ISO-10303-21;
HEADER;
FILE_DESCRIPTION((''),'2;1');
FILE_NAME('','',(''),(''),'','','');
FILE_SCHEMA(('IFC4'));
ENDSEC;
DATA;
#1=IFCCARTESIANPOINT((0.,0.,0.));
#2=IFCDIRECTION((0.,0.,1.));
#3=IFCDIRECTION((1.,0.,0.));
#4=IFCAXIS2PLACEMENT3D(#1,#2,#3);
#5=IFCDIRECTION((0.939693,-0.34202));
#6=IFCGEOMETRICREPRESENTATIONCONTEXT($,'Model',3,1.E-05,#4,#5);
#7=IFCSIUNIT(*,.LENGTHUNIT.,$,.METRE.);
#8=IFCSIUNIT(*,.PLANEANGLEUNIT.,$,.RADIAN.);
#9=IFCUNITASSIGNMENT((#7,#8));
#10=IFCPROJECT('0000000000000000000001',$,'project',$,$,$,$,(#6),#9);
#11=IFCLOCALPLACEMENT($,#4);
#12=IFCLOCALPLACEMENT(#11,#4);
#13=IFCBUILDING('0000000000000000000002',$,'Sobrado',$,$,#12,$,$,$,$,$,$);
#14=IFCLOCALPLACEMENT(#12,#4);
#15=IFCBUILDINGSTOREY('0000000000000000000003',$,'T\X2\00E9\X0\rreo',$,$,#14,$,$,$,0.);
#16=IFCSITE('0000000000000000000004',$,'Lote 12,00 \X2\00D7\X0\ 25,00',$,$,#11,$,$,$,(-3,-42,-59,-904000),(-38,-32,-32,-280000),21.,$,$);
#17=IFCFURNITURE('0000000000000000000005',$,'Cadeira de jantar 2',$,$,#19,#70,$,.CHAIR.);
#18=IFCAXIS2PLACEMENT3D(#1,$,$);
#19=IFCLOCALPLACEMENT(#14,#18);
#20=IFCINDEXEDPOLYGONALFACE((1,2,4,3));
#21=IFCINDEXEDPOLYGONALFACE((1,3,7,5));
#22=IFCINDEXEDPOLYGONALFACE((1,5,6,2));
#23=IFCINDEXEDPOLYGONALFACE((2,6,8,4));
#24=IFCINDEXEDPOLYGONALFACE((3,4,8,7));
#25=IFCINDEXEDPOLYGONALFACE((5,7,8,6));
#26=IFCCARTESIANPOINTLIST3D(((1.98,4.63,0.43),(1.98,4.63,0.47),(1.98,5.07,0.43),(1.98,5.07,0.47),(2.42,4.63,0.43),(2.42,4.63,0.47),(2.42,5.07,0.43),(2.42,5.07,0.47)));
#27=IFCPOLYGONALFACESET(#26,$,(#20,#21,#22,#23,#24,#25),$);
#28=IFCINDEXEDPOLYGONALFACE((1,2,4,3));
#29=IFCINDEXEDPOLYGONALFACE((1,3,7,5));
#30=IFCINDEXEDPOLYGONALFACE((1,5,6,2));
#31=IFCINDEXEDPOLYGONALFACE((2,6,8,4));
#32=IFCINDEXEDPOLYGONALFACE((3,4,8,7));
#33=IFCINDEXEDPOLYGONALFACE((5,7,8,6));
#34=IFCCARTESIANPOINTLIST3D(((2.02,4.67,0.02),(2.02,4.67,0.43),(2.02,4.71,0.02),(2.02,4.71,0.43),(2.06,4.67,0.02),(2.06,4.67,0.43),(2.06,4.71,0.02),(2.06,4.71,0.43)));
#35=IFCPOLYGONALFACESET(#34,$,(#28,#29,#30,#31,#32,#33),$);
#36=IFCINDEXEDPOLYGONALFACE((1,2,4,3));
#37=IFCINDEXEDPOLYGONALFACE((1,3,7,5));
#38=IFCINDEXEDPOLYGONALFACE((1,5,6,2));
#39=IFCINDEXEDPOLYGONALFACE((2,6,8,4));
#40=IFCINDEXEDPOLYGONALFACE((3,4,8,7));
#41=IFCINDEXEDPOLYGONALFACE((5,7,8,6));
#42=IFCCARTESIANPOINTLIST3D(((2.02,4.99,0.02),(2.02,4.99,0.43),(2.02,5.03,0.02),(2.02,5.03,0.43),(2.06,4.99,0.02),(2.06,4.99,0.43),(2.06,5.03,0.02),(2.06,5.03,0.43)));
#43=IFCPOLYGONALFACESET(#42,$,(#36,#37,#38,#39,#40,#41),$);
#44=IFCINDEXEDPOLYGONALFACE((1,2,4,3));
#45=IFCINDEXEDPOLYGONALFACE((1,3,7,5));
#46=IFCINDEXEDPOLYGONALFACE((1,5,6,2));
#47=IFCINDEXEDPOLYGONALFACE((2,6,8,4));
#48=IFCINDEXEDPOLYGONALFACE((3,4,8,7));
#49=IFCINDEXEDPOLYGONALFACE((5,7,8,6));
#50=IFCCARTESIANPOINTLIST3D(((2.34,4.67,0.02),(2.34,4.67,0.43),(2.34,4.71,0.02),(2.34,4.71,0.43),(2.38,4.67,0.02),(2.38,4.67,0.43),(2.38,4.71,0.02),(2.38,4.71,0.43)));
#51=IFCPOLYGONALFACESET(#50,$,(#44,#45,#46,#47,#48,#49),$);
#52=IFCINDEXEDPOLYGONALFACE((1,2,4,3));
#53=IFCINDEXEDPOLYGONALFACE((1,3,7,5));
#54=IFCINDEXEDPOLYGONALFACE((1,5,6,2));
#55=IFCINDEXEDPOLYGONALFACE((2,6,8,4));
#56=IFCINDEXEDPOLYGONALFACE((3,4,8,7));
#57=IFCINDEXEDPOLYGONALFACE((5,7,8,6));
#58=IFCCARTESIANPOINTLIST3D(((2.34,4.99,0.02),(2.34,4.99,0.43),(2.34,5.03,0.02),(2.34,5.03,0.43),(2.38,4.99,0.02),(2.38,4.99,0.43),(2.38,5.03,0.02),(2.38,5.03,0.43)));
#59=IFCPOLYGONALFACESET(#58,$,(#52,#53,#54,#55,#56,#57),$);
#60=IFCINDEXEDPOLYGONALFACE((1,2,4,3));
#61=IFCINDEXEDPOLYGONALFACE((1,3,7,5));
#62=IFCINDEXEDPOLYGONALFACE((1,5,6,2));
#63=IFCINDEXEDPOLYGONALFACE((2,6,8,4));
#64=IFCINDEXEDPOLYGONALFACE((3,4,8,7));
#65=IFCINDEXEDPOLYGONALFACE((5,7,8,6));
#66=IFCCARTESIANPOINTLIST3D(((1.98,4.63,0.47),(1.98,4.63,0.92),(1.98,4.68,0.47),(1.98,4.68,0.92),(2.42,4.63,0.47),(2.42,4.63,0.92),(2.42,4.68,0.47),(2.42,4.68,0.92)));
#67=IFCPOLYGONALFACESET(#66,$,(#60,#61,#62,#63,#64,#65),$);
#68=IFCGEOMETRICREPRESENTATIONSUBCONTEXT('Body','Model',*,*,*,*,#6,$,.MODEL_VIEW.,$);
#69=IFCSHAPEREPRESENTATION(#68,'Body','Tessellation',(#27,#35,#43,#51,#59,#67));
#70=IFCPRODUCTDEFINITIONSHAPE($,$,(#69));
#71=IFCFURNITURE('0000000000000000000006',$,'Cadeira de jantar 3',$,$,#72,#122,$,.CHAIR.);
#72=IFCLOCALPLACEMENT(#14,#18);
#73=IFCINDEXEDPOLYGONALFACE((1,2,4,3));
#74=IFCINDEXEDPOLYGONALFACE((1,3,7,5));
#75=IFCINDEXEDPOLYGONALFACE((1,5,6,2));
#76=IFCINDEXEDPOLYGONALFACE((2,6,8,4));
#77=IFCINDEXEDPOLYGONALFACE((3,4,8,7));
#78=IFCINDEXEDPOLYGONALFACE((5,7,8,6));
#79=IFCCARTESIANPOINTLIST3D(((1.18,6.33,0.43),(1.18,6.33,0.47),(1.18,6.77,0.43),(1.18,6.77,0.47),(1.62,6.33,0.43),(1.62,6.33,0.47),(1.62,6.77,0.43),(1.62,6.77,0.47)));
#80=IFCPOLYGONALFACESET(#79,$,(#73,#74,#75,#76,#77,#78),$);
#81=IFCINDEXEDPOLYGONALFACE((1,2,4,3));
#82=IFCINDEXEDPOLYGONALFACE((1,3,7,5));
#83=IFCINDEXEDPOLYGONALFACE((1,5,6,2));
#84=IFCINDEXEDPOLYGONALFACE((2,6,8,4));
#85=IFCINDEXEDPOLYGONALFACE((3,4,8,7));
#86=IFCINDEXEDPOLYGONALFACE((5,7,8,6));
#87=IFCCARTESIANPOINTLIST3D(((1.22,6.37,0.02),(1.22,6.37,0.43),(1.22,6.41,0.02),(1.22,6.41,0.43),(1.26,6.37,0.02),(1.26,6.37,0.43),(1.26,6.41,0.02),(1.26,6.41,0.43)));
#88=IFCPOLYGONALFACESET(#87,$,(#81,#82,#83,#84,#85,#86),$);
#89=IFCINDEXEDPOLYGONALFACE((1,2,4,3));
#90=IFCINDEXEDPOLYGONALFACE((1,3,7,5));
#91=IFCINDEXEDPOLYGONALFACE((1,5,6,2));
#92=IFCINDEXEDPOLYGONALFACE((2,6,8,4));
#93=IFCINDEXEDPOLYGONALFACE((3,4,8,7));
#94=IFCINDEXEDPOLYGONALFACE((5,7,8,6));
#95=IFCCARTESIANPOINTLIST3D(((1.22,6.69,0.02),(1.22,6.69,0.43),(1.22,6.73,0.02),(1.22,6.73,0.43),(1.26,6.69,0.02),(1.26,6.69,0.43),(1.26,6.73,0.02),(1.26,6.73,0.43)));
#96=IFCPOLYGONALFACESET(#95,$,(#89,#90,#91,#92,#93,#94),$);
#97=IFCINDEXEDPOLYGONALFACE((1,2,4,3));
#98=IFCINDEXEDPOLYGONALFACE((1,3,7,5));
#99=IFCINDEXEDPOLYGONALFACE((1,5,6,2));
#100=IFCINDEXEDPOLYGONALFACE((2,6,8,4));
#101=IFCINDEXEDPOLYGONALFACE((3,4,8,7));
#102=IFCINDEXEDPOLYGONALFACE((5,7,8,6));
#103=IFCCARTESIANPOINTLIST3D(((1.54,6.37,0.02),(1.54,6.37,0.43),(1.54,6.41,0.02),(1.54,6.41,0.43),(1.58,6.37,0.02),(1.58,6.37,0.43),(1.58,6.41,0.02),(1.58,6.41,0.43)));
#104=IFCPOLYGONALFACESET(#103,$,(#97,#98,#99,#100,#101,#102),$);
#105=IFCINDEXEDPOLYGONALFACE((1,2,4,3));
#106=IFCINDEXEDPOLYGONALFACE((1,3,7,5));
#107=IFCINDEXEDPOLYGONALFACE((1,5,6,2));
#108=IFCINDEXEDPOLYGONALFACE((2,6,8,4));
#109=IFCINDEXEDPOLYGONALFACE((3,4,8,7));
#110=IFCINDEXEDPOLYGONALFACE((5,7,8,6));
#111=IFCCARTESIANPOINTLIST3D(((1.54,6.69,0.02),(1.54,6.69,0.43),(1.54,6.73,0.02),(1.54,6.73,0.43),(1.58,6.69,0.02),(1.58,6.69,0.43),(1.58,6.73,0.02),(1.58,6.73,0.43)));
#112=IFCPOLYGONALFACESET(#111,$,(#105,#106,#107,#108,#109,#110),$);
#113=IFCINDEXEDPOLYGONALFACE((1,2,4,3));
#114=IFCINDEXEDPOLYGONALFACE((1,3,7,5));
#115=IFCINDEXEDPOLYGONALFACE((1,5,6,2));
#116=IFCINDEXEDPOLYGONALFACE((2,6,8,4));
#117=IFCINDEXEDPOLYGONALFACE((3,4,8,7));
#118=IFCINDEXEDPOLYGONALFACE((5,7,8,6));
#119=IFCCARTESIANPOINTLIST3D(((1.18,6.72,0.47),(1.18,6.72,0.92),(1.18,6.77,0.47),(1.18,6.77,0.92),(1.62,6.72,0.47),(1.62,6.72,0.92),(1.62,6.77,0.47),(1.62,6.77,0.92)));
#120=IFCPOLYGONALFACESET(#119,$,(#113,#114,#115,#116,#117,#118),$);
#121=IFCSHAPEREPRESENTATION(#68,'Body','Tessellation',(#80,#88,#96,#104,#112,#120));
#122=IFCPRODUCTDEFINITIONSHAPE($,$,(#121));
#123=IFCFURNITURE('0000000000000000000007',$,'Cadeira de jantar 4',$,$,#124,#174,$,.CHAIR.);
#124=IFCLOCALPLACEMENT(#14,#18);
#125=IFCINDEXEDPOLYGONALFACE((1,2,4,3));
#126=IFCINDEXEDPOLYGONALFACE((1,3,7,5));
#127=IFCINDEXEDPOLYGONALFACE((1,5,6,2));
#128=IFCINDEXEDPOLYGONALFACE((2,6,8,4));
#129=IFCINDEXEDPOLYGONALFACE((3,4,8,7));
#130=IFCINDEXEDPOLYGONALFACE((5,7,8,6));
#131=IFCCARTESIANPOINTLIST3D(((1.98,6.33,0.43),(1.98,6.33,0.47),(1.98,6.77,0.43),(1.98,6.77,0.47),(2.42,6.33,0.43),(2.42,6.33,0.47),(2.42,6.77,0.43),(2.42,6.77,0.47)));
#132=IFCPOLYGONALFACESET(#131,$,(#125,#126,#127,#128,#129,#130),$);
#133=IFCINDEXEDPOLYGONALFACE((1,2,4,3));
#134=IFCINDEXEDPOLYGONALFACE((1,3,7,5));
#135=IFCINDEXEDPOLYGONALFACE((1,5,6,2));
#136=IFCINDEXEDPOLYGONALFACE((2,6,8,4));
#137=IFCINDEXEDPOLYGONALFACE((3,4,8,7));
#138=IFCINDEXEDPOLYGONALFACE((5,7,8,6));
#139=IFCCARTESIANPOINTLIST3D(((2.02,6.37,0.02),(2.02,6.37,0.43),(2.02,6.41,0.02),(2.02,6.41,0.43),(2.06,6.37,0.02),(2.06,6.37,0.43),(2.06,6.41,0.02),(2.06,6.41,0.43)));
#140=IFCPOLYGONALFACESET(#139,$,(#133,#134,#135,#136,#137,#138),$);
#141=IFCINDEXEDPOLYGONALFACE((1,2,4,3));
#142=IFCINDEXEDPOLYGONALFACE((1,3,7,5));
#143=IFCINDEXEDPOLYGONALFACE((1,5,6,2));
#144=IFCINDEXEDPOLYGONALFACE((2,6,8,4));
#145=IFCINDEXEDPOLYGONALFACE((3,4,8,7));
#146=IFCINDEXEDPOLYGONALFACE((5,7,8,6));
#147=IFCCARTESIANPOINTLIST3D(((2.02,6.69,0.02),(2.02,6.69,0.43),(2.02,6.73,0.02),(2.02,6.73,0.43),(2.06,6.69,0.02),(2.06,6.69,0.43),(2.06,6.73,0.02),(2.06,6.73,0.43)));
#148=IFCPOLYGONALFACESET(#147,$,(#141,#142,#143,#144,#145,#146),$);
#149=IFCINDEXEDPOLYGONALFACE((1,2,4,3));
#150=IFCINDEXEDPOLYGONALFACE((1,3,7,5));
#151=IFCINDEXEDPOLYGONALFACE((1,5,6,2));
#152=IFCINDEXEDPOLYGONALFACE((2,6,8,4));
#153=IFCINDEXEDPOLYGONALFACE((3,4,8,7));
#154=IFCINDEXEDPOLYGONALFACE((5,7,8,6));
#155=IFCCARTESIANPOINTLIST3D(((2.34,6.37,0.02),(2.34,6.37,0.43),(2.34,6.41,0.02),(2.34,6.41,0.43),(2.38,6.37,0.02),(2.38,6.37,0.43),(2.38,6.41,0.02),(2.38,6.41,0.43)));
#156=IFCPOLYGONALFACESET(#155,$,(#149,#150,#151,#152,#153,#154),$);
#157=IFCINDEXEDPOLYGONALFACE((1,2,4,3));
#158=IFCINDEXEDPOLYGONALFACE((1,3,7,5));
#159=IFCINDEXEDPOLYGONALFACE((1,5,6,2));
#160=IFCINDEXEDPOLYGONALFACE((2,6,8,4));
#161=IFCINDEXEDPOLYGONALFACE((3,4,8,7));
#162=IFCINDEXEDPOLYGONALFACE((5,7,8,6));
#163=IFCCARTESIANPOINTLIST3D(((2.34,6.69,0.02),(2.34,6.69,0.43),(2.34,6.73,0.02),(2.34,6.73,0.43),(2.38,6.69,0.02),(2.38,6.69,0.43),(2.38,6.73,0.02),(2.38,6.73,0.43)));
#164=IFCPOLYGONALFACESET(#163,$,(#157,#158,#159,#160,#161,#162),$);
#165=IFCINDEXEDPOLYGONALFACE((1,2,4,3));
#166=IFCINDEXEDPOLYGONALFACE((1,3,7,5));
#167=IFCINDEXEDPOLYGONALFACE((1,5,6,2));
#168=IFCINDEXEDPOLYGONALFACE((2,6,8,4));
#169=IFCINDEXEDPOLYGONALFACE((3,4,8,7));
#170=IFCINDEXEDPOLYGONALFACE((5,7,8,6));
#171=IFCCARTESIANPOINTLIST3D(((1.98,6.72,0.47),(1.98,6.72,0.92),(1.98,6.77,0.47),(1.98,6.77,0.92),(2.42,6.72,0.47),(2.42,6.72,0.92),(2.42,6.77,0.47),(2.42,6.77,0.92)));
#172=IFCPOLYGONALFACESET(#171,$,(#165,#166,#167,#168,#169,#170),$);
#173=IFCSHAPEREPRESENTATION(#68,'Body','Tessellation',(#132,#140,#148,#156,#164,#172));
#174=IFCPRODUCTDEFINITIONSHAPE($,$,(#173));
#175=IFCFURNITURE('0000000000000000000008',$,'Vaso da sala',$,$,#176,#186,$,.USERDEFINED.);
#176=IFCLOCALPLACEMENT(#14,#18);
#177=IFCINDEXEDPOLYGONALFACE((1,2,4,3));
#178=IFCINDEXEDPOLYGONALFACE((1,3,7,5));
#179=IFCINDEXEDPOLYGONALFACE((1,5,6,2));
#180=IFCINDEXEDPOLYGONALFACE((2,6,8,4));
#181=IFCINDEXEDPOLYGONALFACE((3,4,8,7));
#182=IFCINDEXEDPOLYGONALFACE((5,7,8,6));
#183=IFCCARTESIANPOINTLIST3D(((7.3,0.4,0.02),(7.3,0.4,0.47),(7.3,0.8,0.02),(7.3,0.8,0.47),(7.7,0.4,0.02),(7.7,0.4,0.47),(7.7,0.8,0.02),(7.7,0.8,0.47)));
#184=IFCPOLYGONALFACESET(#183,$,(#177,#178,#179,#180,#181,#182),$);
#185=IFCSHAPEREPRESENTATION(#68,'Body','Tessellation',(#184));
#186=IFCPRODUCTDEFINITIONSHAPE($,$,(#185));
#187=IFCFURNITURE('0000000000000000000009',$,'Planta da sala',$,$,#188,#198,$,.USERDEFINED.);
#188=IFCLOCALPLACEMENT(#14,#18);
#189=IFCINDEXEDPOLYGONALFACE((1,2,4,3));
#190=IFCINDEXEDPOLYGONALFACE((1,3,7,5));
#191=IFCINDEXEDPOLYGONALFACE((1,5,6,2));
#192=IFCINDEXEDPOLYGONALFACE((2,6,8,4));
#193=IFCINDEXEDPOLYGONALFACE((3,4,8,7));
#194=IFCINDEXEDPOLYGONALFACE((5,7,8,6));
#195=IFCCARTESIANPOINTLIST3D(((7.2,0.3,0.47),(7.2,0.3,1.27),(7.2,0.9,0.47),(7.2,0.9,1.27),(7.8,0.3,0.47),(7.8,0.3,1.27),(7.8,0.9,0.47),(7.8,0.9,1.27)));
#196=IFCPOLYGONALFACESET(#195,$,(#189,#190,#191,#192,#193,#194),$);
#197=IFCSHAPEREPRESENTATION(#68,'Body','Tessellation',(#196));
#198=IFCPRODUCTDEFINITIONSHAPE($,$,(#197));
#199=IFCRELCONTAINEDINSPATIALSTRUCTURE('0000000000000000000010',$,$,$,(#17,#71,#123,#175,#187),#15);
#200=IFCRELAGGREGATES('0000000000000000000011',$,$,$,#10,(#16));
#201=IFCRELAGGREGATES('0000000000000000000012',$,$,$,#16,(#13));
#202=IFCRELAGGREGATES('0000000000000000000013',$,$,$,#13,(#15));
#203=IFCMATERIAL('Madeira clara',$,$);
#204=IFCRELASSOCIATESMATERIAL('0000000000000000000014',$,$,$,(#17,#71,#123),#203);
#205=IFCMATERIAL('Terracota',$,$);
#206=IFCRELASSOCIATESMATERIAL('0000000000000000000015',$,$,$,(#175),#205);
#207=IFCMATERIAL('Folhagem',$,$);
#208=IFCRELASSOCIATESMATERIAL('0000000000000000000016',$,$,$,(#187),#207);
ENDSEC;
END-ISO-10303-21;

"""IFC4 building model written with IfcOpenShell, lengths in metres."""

from ifc_helpers import new_model, si_unit, direction, frame, origin_with_axes, place, context, subcontext, project, spatial, line, indexed_curve, outline, extrude, material, element, save


model = new_model("IFC4")

# Units and contexts
model_context = context("Model", 3, precision=1e-05, world=origin_with_axes(), true_north=direction((0.939693, -0.34202)))
body_context = subcontext(model_context, "Body", "Model", "MODEL_VIEW")
ifc_project = project(units=[si_unit("LENGTHUNIT", "METRE"), si_unit("PLANEANGLEUNIT", "RADIAN")], contexts=[model_context])

# Site, building, storey
site_placement = place(None, origin_with_axes())
site = spatial("IfcSite", under=ifc_project, at=site_placement, Name="Lote 12,00 × 25,00", RefLatitude=(-3, -42, -59, -904000), RefLongitude=(-38, -32, -32, -280000), RefElevation=21.0)
building_placement = place(site_placement, origin_with_axes())
building = spatial("IfcBuilding", under=site, at=building_placement, Name="Sobrado")
storey_placement = place(building_placement, origin_with_axes())
storey = spatial("IfcBuildingStorey", under=building, at=storey_placement, Name="Térreo", Elevation=0.0)

# Furniture
ifc_material_1 = material(Name="Madeira clara")
furniture_1_placement = place(storey_placement, origin_with_axes())
element("IfcFurniture", 1, at=furniture_1_placement, inside=storey, material=ifc_material_1, Name="Cadeira de jantar 2", PredefinedType="CHAIR", context=body_context, shape_type="SweptSolid", body=[
    extrude(outline(indexed_curve([(1.98, 4.63), (2.42, 4.63), (2.42, 5.07), (1.98, 5.07)], segments=[line(1, 2, 3, 4, 1)])), frame((0.0, 0.0, 0.43), z_axis=(0.0, 0.0, 1.0), x_axis=(1.0, 0.0, 0.0)), (0.0, 0.0, 1.0), 0.04),
    extrude(outline(indexed_curve([(2.02, 4.67), (2.06, 4.67), (2.06, 4.71), (2.02, 4.71)], segments=[line(1, 2, 3, 4, 1)])), frame((0.0, 0.0, 0.02), z_axis=(0.0, 0.0, 1.0), x_axis=(1.0, 0.0, 0.0)), (0.0, 0.0, 1.0), 0.41),
    extrude(outline(indexed_curve([(2.02, 4.99), (2.06, 4.99), (2.06, 5.03), (2.02, 5.03)], segments=[line(1, 2, 3, 4, 1)])), frame((0.0, 0.0, 0.02), z_axis=(0.0, 0.0, 1.0), x_axis=(1.0, 0.0, 0.0)), (0.0, 0.0, 1.0), 0.41),
    extrude(outline(indexed_curve([(2.34, 4.67), (2.38, 4.67), (2.38, 4.71), (2.34, 4.71)], segments=[line(1, 2, 3, 4, 1)])), frame((0.0, 0.0, 0.02), z_axis=(0.0, 0.0, 1.0), x_axis=(1.0, 0.0, 0.0)), (0.0, 0.0, 1.0), 0.41),
    extrude(outline(indexed_curve([(2.34, 4.99), (2.38, 4.99), (2.38, 5.03), (2.34, 5.03)], segments=[line(1, 2, 3, 4, 1)])), frame((0.0, 0.0, 0.02), z_axis=(0.0, 0.0, 1.0), x_axis=(1.0, 0.0, 0.0)), (0.0, 0.0, 1.0), 0.41),
    extrude(outline(indexed_curve([(1.98, 4.63), (2.42, 4.63), (2.42, 4.68), (1.98, 4.68)], segments=[line(1, 2, 3, 4, 1)])), frame((0.0, 0.0, 0.47), z_axis=(0.0, 0.0, 1.0), x_axis=(1.0, 0.0, 0.0)), (0.0, 0.0, 1.0), 0.45),
])
furniture_2_placement = place(storey_placement, origin_with_axes())
element("IfcFurniture", 2, at=furniture_2_placement, inside=storey, material=ifc_material_1, Name="Cadeira de jantar 3", PredefinedType="CHAIR", context=body_context, shape_type="SweptSolid", body=[
    extrude(outline(indexed_curve([(1.18, 6.33), (1.62, 6.33), (1.62, 6.77), (1.18, 6.77)], segments=[line(1, 2, 3, 4, 1)])), frame((0.0, 0.0, 0.43), z_axis=(0.0, 0.0, 1.0), x_axis=(1.0, 0.0, 0.0)), (0.0, 0.0, 1.0), 0.04),
    extrude(outline(indexed_curve([(1.22, 6.37), (1.26, 6.37), (1.26, 6.41), (1.22, 6.41)], segments=[line(1, 2, 3, 4, 1)])), frame((0.0, 0.0, 0.02), z_axis=(0.0, 0.0, 1.0), x_axis=(1.0, 0.0, 0.0)), (0.0, 0.0, 1.0), 0.41),
    extrude(outline(indexed_curve([(1.22, 6.69), (1.26, 6.69), (1.26, 6.73), (1.22, 6.73)], segments=[line(1, 2, 3, 4, 1)])), frame((0.0, 0.0, 0.02), z_axis=(0.0, 0.0, 1.0), x_axis=(1.0, 0.0, 0.0)), (0.0, 0.0, 1.0), 0.41),
    extrude(outline(indexed_curve([(1.54, 6.37), (1.58, 6.37), (1.58, 6.41), (1.54, 6.41)], segments=[line(1, 2, 3, 4, 1)])), frame((0.0, 0.0, 0.02), z_axis=(0.0, 0.0, 1.0), x_axis=(1.0, 0.0, 0.0)), (0.0, 0.0, 1.0), 0.41),
    extrude(outline(indexed_curve([(1.54, 6.69), (1.58, 6.69), (1.58, 6.73), (1.54, 6.73)], segments=[line(1, 2, 3, 4, 1)])), frame((0.0, 0.0, 0.02), z_axis=(0.0, 0.0, 1.0), x_axis=(1.0, 0.0, 0.0)), (0.0, 0.0, 1.0), 0.41),
    extrude(outline(indexed_curve([(1.18, 6.72), (1.62, 6.72), (1.62, 6.77), (1.18, 6.77)], segments=[line(1, 2, 3, 4, 1)])), frame((0.0, 0.0, 0.47), z_axis=(0.0, 0.0, 1.0), x_axis=(1.0, 0.0, 0.0)), (0.0, 0.0, 1.0), 0.45),
])
furniture_3_placement = place(storey_placement, origin_with_axes())
element("IfcFurniture", 3, at=furniture_3_placement, inside=storey, material=ifc_material_1, Name="Cadeira de jantar 4", PredefinedType="CHAIR", context=body_context, shape_type="SweptSolid", body=[
    extrude(outline(indexed_curve([(1.98, 6.33), (2.42, 6.33), (2.42, 6.77), (1.98, 6.77)], segments=[line(1, 2, 3, 4, 1)])), frame((0.0, 0.0, 0.43), z_axis=(0.0, 0.0, 1.0), x_axis=(1.0, 0.0, 0.0)), (0.0, 0.0, 1.0), 0.04),
    extrude(outline(indexed_curve([(2.02, 6.37), (2.06, 6.37), (2.06, 6.41), (2.02, 6.41)], segments=[line(1, 2, 3, 4, 1)])), frame((0.0, 0.0, 0.02), z_axis=(0.0, 0.0, 1.0), x_axis=(1.0, 0.0, 0.0)), (0.0, 0.0, 1.0), 0.41),
    extrude(outline(indexed_curve([(2.02, 6.69), (2.06, 6.69), (2.06, 6.73), (2.02, 6.73)], segments=[line(1, 2, 3, 4, 1)])), frame((0.0, 0.0, 0.02), z_axis=(0.0, 0.0, 1.0), x_axis=(1.0, 0.0, 0.0)), (0.0, 0.0, 1.0), 0.41),
    extrude(outline(indexed_curve([(2.34, 6.37), (2.38, 6.37), (2.38, 6.41), (2.34, 6.41)], segments=[line(1, 2, 3, 4, 1)])), frame((0.0, 0.0, 0.02), z_axis=(0.0, 0.0, 1.0), x_axis=(1.0, 0.0, 0.0)), (0.0, 0.0, 1.0), 0.41),
    extrude(outline(indexed_curve([(2.34, 6.69), (2.38, 6.69), (2.38, 6.73), (2.34, 6.73)], segments=[line(1, 2, 3, 4, 1)])), frame((0.0, 0.0, 0.02), z_axis=(0.0, 0.0, 1.0), x_axis=(1.0, 0.0, 0.0)), (0.0, 0.0, 1.0), 0.41),
    extrude(outline(indexed_curve([(1.98, 6.72), (2.42, 6.72), (2.42, 6.77), (1.98, 6.77)], segments=[line(1, 2, 3, 4, 1)])), frame((0.0, 0.0, 0.47), z_axis=(0.0, 0.0, 1.0), x_axis=(1.0, 0.0, 0.0)), (0.0, 0.0, 1.0), 0.45),
])
ifc_material_2 = material(Name="Terracota")
furniture_4_placement = place(storey_placement, origin_with_axes())
element("IfcFurniture", 4, at=furniture_4_placement, inside=storey, material=ifc_material_2, Name="Vaso da sala", PredefinedType="USERDEFINED", context=body_context, shape_type="SweptSolid", body=[
    extrude(outline(indexed_curve([(7.3, 0.4), (7.7, 0.4), (7.7, 0.8), (7.3, 0.8)], segments=[line(1, 2, 3, 4, 1)])), frame((0.0, 0.0, 0.02), z_axis=(0.0, 0.0, 1.0), x_axis=(1.0, 0.0, 0.0)), (0.0, 0.0, 1.0), 0.45),
])
ifc_material_3 = material(Name="Folhagem")
furniture_5_placement = place(storey_placement, origin_with_axes())
element("IfcFurniture", 5, at=furniture_5_placement, inside=storey, material=ifc_material_3, Name="Planta da sala", PredefinedType="USERDEFINED", context=body_context, shape_type="SweptSolid", body=[
    extrude(outline(indexed_curve([(7.2, 0.3), (7.8, 0.3), (7.8, 0.9), (7.2, 0.9)], segments=[line(1, 2, 3, 4, 1)])), frame((0.0, 0.0, 0.47), z_axis=(0.0, 0.0, 1.0), x_axis=(1.0, 0.0, 0.0)), (0.0, 0.0, 1.0), 0.8),
])

save(model, "model.ifc")
